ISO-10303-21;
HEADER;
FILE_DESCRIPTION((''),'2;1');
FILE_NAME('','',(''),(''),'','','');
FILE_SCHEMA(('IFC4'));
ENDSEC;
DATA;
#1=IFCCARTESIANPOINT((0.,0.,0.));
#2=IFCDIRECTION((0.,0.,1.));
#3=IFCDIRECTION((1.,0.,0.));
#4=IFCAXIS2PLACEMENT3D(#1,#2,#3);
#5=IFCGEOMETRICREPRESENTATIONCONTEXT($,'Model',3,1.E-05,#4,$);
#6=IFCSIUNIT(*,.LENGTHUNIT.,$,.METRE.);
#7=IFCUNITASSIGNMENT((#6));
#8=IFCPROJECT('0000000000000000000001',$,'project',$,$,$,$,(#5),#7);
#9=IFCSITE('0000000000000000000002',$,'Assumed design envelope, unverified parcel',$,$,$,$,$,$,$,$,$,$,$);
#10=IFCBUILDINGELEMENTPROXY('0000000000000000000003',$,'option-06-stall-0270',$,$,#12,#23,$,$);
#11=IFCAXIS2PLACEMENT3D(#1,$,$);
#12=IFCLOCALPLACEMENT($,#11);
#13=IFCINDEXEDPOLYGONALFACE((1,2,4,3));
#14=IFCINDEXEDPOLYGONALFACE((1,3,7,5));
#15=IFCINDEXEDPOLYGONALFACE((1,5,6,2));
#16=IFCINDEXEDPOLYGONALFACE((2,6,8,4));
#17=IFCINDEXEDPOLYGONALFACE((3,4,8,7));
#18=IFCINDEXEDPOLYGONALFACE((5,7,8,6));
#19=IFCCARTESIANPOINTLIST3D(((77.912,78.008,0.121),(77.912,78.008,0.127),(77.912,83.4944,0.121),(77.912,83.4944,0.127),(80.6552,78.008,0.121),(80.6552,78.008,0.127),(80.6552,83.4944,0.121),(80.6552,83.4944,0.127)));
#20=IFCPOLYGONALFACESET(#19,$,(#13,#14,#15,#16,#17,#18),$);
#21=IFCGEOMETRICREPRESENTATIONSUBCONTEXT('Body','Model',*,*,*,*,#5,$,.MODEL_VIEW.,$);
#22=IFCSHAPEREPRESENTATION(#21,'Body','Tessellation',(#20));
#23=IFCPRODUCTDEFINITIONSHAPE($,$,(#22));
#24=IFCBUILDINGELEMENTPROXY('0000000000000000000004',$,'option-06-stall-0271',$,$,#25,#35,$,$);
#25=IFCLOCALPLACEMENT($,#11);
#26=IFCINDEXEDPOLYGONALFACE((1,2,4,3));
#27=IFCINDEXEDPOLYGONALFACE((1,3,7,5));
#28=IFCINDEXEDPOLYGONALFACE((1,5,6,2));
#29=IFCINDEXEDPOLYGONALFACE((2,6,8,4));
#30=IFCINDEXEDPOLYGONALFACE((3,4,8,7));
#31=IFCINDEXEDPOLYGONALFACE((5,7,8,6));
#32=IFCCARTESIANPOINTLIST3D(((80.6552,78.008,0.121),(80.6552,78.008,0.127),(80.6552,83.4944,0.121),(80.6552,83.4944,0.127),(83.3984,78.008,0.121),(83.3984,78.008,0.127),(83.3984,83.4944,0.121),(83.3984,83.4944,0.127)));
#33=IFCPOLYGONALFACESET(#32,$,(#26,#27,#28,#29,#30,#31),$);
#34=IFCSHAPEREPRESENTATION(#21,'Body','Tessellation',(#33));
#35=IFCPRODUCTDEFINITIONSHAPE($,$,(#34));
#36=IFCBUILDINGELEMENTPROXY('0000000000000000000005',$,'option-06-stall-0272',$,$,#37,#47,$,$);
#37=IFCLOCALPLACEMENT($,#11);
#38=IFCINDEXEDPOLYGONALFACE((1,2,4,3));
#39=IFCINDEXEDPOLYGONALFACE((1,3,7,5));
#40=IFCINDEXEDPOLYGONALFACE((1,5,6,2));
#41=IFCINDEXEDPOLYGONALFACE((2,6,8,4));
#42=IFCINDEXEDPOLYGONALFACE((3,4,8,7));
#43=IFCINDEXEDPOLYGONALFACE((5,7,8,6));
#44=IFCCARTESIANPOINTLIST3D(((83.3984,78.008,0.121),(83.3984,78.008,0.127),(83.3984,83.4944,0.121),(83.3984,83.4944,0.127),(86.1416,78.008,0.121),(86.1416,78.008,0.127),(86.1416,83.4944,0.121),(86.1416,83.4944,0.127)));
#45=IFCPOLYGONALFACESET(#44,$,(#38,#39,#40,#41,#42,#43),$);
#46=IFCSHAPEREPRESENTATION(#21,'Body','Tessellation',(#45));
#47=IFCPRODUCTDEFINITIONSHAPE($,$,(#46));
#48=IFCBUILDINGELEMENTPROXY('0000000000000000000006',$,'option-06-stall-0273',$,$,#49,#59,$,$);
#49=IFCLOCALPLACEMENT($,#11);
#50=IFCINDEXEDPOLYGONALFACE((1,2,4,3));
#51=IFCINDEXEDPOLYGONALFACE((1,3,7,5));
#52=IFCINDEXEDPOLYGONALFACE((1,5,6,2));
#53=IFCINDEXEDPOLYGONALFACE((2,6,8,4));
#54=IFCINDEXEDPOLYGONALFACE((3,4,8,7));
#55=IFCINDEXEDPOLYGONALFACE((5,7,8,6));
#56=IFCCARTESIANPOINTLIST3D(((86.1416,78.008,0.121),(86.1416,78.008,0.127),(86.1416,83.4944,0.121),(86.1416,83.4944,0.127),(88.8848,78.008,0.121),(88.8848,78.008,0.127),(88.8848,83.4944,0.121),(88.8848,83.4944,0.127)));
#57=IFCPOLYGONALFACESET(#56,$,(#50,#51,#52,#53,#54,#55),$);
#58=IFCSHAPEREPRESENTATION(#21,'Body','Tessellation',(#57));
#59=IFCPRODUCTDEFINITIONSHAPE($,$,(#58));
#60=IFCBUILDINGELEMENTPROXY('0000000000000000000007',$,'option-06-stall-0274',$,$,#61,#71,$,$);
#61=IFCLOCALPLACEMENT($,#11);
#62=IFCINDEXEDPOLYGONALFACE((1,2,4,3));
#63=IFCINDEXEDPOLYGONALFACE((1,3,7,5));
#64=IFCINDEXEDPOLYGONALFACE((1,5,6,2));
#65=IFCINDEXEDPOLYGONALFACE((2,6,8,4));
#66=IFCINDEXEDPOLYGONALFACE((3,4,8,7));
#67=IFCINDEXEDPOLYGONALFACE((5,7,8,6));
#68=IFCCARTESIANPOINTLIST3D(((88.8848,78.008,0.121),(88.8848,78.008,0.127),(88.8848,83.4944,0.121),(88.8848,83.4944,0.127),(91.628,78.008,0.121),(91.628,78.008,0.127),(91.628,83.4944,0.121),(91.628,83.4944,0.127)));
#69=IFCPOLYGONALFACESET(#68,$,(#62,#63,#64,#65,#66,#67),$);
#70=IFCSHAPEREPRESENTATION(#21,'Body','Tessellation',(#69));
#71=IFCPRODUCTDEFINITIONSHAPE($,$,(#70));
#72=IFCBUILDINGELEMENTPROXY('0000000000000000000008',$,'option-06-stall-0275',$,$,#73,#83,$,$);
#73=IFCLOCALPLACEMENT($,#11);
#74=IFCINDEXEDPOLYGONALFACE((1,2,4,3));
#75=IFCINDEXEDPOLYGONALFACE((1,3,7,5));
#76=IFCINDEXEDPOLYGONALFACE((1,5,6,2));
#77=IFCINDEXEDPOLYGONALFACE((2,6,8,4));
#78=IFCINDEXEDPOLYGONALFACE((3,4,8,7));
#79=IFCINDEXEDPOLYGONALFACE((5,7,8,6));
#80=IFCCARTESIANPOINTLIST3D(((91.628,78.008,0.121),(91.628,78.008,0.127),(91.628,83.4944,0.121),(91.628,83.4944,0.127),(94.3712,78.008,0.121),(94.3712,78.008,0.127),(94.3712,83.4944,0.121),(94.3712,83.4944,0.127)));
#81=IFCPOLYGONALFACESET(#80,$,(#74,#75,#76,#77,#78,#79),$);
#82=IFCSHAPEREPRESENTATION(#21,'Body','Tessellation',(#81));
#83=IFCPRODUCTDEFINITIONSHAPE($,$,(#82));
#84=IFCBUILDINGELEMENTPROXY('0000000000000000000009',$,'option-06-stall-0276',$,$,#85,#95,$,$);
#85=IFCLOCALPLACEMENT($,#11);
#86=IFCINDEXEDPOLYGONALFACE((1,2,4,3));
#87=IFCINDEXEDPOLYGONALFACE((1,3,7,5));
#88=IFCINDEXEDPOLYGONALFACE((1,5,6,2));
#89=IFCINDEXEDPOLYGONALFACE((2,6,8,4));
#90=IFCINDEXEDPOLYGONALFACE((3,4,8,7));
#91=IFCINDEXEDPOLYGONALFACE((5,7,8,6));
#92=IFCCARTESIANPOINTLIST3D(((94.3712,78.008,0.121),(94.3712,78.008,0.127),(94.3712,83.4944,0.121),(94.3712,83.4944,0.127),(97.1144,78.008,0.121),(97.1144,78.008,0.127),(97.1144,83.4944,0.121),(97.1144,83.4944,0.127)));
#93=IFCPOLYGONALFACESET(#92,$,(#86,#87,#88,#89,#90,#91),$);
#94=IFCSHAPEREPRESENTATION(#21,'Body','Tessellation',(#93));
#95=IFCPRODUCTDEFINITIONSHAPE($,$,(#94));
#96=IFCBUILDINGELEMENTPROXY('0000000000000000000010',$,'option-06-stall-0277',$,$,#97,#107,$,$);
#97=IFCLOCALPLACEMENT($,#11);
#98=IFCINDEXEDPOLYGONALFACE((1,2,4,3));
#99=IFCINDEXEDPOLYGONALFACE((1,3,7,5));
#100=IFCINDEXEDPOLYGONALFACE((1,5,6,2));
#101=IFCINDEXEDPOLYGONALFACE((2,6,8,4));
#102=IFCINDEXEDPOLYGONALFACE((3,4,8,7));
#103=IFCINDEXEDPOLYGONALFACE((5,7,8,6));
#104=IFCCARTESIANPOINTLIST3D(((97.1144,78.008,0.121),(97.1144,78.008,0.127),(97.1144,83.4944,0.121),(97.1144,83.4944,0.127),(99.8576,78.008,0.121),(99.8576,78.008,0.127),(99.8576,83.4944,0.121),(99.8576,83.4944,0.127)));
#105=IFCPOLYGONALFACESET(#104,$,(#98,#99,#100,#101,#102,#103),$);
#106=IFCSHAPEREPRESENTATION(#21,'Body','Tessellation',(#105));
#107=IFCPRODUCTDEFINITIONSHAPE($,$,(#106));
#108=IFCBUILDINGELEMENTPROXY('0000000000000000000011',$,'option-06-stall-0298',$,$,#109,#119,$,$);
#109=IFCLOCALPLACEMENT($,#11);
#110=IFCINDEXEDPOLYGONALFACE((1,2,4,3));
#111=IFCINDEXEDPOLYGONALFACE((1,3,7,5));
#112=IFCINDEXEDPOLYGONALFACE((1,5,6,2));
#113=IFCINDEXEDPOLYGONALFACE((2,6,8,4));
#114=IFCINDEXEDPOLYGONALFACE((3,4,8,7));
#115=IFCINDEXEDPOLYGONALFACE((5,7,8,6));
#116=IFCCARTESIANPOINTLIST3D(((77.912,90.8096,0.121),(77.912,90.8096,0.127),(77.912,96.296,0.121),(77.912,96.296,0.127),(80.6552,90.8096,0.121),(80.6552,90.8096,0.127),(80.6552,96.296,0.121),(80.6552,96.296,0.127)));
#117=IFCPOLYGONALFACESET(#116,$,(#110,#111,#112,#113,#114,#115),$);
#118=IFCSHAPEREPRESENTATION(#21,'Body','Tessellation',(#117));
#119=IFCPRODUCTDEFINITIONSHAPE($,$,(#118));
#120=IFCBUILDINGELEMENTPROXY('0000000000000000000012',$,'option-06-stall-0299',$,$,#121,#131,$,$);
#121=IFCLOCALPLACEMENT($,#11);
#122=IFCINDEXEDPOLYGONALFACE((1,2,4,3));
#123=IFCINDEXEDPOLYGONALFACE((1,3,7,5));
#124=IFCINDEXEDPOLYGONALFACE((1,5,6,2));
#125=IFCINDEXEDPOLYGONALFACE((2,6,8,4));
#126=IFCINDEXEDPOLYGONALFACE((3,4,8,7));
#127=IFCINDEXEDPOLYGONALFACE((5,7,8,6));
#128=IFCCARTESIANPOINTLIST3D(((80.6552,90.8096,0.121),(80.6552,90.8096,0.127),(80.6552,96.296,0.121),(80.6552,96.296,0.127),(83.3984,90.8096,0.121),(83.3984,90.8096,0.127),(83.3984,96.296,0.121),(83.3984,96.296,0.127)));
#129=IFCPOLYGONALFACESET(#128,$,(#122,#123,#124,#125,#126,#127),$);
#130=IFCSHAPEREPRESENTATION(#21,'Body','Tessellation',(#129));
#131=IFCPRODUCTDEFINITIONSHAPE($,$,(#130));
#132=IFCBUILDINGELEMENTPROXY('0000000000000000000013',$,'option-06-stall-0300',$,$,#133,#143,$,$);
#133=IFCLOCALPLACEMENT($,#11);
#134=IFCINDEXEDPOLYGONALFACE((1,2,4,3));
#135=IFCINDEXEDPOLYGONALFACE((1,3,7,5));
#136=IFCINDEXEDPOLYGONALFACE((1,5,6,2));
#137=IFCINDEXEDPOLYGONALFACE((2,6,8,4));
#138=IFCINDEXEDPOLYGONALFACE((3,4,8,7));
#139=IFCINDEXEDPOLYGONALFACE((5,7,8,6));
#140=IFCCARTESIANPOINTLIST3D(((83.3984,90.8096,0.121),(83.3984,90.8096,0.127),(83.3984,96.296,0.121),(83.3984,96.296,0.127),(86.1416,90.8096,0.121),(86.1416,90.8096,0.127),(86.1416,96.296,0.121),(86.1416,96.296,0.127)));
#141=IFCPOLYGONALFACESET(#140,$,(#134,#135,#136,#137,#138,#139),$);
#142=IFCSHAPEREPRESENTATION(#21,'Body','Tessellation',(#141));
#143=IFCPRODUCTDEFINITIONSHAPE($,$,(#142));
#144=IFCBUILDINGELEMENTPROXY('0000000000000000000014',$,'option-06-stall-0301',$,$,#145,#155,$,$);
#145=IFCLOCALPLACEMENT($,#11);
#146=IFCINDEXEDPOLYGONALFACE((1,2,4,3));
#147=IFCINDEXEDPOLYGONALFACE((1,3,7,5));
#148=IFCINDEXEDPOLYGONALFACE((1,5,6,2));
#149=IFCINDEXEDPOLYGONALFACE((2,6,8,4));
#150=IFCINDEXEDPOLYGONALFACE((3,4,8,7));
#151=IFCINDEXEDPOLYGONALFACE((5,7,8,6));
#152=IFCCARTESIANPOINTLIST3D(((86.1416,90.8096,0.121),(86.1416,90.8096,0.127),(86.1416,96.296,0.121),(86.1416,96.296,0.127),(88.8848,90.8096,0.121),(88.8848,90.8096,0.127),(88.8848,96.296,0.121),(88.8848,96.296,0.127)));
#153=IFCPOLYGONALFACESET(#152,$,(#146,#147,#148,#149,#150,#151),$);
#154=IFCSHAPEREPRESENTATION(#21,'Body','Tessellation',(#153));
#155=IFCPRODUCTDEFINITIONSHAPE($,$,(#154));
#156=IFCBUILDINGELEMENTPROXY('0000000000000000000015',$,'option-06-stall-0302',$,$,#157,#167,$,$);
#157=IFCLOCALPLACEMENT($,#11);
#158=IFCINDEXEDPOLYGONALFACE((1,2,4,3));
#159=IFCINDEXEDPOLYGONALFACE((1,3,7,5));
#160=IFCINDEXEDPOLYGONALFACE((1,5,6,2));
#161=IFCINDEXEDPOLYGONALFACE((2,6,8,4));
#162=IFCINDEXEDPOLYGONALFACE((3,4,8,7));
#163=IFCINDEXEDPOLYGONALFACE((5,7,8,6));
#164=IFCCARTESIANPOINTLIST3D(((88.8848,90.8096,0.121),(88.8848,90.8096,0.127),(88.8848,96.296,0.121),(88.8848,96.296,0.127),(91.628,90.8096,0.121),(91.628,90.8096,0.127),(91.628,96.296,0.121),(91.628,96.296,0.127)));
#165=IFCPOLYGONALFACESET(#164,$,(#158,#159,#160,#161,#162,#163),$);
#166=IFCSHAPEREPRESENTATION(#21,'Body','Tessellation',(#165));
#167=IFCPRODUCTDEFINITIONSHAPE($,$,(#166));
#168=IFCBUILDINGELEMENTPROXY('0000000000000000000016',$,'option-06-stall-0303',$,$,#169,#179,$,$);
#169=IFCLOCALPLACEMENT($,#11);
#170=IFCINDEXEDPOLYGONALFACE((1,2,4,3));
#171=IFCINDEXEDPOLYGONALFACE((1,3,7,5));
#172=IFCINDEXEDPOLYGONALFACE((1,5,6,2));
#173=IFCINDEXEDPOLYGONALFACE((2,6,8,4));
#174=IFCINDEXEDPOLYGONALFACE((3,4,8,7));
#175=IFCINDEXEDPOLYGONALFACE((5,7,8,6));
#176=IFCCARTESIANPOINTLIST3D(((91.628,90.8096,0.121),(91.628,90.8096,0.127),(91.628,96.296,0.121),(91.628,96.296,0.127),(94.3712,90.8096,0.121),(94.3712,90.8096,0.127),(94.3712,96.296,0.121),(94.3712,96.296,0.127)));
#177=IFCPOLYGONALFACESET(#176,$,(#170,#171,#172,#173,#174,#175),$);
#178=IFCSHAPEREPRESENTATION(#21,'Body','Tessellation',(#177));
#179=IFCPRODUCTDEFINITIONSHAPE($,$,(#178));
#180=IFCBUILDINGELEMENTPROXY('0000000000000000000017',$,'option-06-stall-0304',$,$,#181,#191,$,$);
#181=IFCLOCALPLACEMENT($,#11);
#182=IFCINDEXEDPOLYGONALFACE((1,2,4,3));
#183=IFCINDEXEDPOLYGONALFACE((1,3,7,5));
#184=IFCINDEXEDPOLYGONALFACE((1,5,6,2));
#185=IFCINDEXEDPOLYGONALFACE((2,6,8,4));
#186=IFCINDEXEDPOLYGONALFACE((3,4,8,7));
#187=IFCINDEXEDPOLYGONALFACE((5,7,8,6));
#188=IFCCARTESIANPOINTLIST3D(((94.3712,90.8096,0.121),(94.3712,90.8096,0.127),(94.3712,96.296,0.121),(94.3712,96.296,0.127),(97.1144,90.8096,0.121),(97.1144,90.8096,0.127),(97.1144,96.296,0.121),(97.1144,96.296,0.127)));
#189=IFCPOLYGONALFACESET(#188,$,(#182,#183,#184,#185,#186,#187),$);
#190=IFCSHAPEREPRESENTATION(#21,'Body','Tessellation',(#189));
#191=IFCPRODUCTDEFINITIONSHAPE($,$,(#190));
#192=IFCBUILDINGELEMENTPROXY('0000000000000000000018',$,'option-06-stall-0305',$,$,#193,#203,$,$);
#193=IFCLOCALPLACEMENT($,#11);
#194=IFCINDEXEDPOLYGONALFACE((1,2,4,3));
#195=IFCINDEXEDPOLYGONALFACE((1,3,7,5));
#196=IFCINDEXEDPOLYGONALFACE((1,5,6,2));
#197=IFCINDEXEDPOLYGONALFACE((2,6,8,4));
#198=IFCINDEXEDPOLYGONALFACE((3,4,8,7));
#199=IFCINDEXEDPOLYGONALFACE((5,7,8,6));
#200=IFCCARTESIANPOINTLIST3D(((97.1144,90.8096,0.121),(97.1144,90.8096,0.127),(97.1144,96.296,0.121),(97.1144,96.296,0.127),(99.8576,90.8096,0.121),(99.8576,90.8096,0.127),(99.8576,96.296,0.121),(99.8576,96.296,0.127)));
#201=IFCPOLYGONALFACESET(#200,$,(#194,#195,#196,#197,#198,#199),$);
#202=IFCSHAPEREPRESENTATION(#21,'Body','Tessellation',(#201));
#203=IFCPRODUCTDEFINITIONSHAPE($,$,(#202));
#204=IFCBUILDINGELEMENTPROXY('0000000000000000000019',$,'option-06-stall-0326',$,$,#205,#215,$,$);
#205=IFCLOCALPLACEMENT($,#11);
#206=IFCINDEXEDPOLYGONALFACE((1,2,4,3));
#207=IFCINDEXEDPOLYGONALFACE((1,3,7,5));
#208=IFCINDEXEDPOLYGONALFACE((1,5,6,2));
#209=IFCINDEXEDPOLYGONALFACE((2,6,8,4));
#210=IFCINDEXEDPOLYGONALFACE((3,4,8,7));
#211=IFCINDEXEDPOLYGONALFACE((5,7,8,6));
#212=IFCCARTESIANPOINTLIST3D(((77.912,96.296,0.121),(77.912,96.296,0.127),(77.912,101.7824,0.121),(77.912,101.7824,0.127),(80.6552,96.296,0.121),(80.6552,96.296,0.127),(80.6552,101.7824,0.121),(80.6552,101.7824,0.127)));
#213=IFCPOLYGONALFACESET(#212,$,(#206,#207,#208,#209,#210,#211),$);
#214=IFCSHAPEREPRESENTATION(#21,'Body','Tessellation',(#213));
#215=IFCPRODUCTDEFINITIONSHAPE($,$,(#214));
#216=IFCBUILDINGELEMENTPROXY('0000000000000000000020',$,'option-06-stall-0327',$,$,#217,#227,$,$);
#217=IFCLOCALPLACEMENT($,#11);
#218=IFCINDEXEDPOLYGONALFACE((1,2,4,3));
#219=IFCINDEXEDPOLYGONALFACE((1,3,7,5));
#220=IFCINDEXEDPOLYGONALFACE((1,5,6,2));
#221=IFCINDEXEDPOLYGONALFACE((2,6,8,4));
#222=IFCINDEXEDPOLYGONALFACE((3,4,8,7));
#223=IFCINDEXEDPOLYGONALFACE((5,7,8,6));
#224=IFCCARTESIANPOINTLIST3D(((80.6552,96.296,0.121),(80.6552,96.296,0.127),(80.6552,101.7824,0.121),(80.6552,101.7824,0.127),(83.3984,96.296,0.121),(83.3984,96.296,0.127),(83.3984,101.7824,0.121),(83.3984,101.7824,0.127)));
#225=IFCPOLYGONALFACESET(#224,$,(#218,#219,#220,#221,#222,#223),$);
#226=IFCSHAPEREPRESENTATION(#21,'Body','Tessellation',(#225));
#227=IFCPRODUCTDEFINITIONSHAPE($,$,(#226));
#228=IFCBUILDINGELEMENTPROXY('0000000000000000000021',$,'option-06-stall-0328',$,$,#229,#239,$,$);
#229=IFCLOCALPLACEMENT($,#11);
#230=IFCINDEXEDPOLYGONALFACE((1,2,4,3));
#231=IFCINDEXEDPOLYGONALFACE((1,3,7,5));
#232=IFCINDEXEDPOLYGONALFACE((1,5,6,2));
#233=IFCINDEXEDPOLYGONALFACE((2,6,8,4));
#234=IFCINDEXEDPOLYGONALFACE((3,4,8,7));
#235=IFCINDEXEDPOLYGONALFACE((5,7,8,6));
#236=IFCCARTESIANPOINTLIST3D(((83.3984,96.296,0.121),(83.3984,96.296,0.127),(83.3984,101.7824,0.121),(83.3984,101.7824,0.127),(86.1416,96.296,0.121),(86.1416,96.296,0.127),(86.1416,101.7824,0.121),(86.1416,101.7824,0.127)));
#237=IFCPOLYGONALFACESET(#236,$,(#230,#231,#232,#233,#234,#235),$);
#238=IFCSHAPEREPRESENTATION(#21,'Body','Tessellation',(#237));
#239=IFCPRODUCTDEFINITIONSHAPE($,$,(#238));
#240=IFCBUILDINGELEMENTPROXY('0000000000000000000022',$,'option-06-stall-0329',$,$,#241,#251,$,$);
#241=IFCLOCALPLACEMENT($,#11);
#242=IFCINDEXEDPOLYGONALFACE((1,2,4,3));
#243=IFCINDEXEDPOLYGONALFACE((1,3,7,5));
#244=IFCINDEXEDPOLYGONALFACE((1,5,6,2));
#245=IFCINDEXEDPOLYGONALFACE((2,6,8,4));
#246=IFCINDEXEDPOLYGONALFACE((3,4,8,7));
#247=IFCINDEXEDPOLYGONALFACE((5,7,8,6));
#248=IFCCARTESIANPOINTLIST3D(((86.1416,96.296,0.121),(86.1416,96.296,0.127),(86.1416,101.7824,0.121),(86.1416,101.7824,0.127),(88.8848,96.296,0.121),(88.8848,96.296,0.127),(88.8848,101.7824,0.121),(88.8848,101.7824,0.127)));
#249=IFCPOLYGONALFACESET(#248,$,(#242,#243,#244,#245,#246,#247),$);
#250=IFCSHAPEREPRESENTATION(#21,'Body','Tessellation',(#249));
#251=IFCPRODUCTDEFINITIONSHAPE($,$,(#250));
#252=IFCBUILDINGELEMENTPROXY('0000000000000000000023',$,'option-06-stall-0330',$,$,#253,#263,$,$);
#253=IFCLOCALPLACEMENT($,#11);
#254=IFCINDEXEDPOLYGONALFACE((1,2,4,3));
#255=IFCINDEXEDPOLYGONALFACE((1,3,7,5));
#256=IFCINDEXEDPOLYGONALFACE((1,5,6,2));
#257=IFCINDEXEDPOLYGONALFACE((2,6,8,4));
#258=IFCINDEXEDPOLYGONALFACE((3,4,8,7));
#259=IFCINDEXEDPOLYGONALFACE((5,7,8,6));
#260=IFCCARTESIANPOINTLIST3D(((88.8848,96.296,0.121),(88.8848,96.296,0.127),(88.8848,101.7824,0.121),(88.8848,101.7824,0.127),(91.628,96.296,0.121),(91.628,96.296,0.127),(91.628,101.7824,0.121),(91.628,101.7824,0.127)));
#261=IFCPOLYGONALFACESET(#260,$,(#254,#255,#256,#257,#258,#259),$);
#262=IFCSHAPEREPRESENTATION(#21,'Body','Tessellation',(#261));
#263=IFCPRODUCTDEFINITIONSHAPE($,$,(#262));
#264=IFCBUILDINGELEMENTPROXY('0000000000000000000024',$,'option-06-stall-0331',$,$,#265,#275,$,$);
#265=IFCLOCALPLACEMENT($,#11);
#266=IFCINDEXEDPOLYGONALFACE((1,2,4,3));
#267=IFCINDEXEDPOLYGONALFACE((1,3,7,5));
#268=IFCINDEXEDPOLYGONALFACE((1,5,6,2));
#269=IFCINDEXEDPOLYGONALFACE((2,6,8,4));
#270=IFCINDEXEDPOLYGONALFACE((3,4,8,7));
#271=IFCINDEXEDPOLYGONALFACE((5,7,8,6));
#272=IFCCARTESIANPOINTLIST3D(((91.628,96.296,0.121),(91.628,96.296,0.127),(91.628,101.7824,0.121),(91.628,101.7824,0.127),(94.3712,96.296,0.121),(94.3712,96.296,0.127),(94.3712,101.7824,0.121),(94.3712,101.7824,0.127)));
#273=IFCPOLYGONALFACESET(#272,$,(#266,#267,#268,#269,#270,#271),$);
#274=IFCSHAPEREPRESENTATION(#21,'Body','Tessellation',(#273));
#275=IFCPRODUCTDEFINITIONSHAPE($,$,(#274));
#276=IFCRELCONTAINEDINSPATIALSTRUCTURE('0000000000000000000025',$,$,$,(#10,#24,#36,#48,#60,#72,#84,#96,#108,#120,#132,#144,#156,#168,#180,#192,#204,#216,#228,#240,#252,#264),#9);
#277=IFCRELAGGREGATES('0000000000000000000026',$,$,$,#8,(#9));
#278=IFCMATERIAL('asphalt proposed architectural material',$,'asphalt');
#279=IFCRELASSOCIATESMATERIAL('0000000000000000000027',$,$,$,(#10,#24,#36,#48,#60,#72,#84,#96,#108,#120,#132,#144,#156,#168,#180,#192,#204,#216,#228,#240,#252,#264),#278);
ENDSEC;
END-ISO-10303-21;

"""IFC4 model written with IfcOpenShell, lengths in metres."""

from ifc_helpers import new_model, si_unit, frame, origin_with_axes, place, context, subcontext, project, spatial, rectangle, extrude, material, element, save


model = new_model("IFC4")

# Units and contexts
model_context = context("Model", 3, precision=1e-05, world=origin_with_axes())
body_context = subcontext(model_context, "Body", "Model", "MODEL_VIEW")
ifc_project = project(units=[si_unit("LENGTHUNIT", "METRE")], contexts=[model_context])

# Site
site = spatial("IfcSite", under=ifc_project, Name="Assumed design envelope, unverified parcel")

# Building element proxies
ifc_material = material(Name="asphalt proposed architectural material", Category="asphalt")
for number, where, z_axis, x_axis, name in (
    (1, (79.2836, 80.7512, 0.121), (0.0, 0.0, 1.0), (1.0, 0.0, 0.0), "option-06-stall-0270"),
    (2, (82.0268, 80.7512, 0.121), (0.0, 0.0, 1.0), (1.0, 0.0, 0.0), "option-06-stall-0271"),
    (3, (84.77, 80.7512, 0.121), (0.0, 0.0, 1.0), (1.0, 0.0, 0.0), "option-06-stall-0272"),
    (4, (87.5132, 80.7512, 0.121), (0.0, 0.0, 1.0), (1.0, 0.0, 0.0), "option-06-stall-0273"),
    (5, (90.2564, 80.7512, 0.121), (0.0, 0.0, 1.0), (1.0, 0.0, 0.0), "option-06-stall-0274"),
    (6, (92.9996, 80.7512, 0.121), (0.0, 0.0, 1.0), (1.0, 0.0, 0.0), "option-06-stall-0275"),
    (7, (95.7428, 80.7512, 0.121), (0.0, 0.0, 1.0), (1.0, 0.0, 0.0), "option-06-stall-0276"),
    (8, (98.486, 80.7512, 0.121), (0.0, 0.0, 1.0), (1.0, 0.0, 0.0), "option-06-stall-0277"),
    (9, (79.2836, 93.5528, 0.121), (0.0, 0.0, 1.0), (1.0, 0.0, 0.0), "option-06-stall-0298"),
    (10, (82.0268, 93.5528, 0.121), (0.0, 0.0, 1.0), (1.0, 0.0, 0.0), "option-06-stall-0299"),
    (11, (84.77, 93.5528, 0.121), (0.0, 0.0, 1.0), (1.0, 0.0, 0.0), "option-06-stall-0300"),
    (12, (87.5132, 93.5528, 0.121), (0.0, 0.0, 1.0), (1.0, 0.0, 0.0), "option-06-stall-0301"),
    (13, (90.2564, 93.5528, 0.121), (0.0, 0.0, 1.0), (1.0, 0.0, 0.0), "option-06-stall-0302"),
    (14, (92.9996, 93.5528, 0.121), (0.0, 0.0, 1.0), (1.0, 0.0, 0.0), "option-06-stall-0303"),
    (15, (95.7428, 93.5528, 0.121), (0.0, 0.0, 1.0), (1.0, 0.0, 0.0), "option-06-stall-0304"),
    (16, (98.486, 93.5528, 0.121), (0.0, 0.0, 1.0), (1.0, 0.0, 0.0), "option-06-stall-0305"),
    (17, (79.2836, 99.0392, 0.121), (0.0, 0.0, 1.0), (1.0, 0.0, 0.0), "option-06-stall-0326"),
    (18, (82.0268, 99.0392, 0.121), (0.0, 0.0, 1.0), (1.0, 0.0, 0.0), "option-06-stall-0327"),
    (19, (84.77, 99.0392, 0.121), (0.0, 0.0, 1.0), (1.0, 0.0, 0.0), "option-06-stall-0328"),
    (20, (87.5132, 99.0392, 0.121), (0.0, 0.0, 1.0), (1.0, 0.0, 0.0), "option-06-stall-0329"),
    (21, (90.2564, 99.0392, 0.121), (0.0, 0.0, 1.0), (1.0, 0.0, 0.0), "option-06-stall-0330"),
    (22, (92.9996, 99.0392, 0.121), (0.0, 0.0, 1.0), (1.0, 0.0, 0.0), "option-06-stall-0331"),
):
    element("IfcBuildingElementProxy", number, at=place(None, frame(where, z_axis=z_axis, x_axis=x_axis)), inside=site, material=ifc_material, Name=name, context=body_context, shape_type="SweptSolid", body=[
        extrude(rectangle(XDim=2.7432, YDim=5.4864), origin_with_axes(), (0.0, 0.0, 1.0), 0.006),
    ])

save(model, "model.ifc")
